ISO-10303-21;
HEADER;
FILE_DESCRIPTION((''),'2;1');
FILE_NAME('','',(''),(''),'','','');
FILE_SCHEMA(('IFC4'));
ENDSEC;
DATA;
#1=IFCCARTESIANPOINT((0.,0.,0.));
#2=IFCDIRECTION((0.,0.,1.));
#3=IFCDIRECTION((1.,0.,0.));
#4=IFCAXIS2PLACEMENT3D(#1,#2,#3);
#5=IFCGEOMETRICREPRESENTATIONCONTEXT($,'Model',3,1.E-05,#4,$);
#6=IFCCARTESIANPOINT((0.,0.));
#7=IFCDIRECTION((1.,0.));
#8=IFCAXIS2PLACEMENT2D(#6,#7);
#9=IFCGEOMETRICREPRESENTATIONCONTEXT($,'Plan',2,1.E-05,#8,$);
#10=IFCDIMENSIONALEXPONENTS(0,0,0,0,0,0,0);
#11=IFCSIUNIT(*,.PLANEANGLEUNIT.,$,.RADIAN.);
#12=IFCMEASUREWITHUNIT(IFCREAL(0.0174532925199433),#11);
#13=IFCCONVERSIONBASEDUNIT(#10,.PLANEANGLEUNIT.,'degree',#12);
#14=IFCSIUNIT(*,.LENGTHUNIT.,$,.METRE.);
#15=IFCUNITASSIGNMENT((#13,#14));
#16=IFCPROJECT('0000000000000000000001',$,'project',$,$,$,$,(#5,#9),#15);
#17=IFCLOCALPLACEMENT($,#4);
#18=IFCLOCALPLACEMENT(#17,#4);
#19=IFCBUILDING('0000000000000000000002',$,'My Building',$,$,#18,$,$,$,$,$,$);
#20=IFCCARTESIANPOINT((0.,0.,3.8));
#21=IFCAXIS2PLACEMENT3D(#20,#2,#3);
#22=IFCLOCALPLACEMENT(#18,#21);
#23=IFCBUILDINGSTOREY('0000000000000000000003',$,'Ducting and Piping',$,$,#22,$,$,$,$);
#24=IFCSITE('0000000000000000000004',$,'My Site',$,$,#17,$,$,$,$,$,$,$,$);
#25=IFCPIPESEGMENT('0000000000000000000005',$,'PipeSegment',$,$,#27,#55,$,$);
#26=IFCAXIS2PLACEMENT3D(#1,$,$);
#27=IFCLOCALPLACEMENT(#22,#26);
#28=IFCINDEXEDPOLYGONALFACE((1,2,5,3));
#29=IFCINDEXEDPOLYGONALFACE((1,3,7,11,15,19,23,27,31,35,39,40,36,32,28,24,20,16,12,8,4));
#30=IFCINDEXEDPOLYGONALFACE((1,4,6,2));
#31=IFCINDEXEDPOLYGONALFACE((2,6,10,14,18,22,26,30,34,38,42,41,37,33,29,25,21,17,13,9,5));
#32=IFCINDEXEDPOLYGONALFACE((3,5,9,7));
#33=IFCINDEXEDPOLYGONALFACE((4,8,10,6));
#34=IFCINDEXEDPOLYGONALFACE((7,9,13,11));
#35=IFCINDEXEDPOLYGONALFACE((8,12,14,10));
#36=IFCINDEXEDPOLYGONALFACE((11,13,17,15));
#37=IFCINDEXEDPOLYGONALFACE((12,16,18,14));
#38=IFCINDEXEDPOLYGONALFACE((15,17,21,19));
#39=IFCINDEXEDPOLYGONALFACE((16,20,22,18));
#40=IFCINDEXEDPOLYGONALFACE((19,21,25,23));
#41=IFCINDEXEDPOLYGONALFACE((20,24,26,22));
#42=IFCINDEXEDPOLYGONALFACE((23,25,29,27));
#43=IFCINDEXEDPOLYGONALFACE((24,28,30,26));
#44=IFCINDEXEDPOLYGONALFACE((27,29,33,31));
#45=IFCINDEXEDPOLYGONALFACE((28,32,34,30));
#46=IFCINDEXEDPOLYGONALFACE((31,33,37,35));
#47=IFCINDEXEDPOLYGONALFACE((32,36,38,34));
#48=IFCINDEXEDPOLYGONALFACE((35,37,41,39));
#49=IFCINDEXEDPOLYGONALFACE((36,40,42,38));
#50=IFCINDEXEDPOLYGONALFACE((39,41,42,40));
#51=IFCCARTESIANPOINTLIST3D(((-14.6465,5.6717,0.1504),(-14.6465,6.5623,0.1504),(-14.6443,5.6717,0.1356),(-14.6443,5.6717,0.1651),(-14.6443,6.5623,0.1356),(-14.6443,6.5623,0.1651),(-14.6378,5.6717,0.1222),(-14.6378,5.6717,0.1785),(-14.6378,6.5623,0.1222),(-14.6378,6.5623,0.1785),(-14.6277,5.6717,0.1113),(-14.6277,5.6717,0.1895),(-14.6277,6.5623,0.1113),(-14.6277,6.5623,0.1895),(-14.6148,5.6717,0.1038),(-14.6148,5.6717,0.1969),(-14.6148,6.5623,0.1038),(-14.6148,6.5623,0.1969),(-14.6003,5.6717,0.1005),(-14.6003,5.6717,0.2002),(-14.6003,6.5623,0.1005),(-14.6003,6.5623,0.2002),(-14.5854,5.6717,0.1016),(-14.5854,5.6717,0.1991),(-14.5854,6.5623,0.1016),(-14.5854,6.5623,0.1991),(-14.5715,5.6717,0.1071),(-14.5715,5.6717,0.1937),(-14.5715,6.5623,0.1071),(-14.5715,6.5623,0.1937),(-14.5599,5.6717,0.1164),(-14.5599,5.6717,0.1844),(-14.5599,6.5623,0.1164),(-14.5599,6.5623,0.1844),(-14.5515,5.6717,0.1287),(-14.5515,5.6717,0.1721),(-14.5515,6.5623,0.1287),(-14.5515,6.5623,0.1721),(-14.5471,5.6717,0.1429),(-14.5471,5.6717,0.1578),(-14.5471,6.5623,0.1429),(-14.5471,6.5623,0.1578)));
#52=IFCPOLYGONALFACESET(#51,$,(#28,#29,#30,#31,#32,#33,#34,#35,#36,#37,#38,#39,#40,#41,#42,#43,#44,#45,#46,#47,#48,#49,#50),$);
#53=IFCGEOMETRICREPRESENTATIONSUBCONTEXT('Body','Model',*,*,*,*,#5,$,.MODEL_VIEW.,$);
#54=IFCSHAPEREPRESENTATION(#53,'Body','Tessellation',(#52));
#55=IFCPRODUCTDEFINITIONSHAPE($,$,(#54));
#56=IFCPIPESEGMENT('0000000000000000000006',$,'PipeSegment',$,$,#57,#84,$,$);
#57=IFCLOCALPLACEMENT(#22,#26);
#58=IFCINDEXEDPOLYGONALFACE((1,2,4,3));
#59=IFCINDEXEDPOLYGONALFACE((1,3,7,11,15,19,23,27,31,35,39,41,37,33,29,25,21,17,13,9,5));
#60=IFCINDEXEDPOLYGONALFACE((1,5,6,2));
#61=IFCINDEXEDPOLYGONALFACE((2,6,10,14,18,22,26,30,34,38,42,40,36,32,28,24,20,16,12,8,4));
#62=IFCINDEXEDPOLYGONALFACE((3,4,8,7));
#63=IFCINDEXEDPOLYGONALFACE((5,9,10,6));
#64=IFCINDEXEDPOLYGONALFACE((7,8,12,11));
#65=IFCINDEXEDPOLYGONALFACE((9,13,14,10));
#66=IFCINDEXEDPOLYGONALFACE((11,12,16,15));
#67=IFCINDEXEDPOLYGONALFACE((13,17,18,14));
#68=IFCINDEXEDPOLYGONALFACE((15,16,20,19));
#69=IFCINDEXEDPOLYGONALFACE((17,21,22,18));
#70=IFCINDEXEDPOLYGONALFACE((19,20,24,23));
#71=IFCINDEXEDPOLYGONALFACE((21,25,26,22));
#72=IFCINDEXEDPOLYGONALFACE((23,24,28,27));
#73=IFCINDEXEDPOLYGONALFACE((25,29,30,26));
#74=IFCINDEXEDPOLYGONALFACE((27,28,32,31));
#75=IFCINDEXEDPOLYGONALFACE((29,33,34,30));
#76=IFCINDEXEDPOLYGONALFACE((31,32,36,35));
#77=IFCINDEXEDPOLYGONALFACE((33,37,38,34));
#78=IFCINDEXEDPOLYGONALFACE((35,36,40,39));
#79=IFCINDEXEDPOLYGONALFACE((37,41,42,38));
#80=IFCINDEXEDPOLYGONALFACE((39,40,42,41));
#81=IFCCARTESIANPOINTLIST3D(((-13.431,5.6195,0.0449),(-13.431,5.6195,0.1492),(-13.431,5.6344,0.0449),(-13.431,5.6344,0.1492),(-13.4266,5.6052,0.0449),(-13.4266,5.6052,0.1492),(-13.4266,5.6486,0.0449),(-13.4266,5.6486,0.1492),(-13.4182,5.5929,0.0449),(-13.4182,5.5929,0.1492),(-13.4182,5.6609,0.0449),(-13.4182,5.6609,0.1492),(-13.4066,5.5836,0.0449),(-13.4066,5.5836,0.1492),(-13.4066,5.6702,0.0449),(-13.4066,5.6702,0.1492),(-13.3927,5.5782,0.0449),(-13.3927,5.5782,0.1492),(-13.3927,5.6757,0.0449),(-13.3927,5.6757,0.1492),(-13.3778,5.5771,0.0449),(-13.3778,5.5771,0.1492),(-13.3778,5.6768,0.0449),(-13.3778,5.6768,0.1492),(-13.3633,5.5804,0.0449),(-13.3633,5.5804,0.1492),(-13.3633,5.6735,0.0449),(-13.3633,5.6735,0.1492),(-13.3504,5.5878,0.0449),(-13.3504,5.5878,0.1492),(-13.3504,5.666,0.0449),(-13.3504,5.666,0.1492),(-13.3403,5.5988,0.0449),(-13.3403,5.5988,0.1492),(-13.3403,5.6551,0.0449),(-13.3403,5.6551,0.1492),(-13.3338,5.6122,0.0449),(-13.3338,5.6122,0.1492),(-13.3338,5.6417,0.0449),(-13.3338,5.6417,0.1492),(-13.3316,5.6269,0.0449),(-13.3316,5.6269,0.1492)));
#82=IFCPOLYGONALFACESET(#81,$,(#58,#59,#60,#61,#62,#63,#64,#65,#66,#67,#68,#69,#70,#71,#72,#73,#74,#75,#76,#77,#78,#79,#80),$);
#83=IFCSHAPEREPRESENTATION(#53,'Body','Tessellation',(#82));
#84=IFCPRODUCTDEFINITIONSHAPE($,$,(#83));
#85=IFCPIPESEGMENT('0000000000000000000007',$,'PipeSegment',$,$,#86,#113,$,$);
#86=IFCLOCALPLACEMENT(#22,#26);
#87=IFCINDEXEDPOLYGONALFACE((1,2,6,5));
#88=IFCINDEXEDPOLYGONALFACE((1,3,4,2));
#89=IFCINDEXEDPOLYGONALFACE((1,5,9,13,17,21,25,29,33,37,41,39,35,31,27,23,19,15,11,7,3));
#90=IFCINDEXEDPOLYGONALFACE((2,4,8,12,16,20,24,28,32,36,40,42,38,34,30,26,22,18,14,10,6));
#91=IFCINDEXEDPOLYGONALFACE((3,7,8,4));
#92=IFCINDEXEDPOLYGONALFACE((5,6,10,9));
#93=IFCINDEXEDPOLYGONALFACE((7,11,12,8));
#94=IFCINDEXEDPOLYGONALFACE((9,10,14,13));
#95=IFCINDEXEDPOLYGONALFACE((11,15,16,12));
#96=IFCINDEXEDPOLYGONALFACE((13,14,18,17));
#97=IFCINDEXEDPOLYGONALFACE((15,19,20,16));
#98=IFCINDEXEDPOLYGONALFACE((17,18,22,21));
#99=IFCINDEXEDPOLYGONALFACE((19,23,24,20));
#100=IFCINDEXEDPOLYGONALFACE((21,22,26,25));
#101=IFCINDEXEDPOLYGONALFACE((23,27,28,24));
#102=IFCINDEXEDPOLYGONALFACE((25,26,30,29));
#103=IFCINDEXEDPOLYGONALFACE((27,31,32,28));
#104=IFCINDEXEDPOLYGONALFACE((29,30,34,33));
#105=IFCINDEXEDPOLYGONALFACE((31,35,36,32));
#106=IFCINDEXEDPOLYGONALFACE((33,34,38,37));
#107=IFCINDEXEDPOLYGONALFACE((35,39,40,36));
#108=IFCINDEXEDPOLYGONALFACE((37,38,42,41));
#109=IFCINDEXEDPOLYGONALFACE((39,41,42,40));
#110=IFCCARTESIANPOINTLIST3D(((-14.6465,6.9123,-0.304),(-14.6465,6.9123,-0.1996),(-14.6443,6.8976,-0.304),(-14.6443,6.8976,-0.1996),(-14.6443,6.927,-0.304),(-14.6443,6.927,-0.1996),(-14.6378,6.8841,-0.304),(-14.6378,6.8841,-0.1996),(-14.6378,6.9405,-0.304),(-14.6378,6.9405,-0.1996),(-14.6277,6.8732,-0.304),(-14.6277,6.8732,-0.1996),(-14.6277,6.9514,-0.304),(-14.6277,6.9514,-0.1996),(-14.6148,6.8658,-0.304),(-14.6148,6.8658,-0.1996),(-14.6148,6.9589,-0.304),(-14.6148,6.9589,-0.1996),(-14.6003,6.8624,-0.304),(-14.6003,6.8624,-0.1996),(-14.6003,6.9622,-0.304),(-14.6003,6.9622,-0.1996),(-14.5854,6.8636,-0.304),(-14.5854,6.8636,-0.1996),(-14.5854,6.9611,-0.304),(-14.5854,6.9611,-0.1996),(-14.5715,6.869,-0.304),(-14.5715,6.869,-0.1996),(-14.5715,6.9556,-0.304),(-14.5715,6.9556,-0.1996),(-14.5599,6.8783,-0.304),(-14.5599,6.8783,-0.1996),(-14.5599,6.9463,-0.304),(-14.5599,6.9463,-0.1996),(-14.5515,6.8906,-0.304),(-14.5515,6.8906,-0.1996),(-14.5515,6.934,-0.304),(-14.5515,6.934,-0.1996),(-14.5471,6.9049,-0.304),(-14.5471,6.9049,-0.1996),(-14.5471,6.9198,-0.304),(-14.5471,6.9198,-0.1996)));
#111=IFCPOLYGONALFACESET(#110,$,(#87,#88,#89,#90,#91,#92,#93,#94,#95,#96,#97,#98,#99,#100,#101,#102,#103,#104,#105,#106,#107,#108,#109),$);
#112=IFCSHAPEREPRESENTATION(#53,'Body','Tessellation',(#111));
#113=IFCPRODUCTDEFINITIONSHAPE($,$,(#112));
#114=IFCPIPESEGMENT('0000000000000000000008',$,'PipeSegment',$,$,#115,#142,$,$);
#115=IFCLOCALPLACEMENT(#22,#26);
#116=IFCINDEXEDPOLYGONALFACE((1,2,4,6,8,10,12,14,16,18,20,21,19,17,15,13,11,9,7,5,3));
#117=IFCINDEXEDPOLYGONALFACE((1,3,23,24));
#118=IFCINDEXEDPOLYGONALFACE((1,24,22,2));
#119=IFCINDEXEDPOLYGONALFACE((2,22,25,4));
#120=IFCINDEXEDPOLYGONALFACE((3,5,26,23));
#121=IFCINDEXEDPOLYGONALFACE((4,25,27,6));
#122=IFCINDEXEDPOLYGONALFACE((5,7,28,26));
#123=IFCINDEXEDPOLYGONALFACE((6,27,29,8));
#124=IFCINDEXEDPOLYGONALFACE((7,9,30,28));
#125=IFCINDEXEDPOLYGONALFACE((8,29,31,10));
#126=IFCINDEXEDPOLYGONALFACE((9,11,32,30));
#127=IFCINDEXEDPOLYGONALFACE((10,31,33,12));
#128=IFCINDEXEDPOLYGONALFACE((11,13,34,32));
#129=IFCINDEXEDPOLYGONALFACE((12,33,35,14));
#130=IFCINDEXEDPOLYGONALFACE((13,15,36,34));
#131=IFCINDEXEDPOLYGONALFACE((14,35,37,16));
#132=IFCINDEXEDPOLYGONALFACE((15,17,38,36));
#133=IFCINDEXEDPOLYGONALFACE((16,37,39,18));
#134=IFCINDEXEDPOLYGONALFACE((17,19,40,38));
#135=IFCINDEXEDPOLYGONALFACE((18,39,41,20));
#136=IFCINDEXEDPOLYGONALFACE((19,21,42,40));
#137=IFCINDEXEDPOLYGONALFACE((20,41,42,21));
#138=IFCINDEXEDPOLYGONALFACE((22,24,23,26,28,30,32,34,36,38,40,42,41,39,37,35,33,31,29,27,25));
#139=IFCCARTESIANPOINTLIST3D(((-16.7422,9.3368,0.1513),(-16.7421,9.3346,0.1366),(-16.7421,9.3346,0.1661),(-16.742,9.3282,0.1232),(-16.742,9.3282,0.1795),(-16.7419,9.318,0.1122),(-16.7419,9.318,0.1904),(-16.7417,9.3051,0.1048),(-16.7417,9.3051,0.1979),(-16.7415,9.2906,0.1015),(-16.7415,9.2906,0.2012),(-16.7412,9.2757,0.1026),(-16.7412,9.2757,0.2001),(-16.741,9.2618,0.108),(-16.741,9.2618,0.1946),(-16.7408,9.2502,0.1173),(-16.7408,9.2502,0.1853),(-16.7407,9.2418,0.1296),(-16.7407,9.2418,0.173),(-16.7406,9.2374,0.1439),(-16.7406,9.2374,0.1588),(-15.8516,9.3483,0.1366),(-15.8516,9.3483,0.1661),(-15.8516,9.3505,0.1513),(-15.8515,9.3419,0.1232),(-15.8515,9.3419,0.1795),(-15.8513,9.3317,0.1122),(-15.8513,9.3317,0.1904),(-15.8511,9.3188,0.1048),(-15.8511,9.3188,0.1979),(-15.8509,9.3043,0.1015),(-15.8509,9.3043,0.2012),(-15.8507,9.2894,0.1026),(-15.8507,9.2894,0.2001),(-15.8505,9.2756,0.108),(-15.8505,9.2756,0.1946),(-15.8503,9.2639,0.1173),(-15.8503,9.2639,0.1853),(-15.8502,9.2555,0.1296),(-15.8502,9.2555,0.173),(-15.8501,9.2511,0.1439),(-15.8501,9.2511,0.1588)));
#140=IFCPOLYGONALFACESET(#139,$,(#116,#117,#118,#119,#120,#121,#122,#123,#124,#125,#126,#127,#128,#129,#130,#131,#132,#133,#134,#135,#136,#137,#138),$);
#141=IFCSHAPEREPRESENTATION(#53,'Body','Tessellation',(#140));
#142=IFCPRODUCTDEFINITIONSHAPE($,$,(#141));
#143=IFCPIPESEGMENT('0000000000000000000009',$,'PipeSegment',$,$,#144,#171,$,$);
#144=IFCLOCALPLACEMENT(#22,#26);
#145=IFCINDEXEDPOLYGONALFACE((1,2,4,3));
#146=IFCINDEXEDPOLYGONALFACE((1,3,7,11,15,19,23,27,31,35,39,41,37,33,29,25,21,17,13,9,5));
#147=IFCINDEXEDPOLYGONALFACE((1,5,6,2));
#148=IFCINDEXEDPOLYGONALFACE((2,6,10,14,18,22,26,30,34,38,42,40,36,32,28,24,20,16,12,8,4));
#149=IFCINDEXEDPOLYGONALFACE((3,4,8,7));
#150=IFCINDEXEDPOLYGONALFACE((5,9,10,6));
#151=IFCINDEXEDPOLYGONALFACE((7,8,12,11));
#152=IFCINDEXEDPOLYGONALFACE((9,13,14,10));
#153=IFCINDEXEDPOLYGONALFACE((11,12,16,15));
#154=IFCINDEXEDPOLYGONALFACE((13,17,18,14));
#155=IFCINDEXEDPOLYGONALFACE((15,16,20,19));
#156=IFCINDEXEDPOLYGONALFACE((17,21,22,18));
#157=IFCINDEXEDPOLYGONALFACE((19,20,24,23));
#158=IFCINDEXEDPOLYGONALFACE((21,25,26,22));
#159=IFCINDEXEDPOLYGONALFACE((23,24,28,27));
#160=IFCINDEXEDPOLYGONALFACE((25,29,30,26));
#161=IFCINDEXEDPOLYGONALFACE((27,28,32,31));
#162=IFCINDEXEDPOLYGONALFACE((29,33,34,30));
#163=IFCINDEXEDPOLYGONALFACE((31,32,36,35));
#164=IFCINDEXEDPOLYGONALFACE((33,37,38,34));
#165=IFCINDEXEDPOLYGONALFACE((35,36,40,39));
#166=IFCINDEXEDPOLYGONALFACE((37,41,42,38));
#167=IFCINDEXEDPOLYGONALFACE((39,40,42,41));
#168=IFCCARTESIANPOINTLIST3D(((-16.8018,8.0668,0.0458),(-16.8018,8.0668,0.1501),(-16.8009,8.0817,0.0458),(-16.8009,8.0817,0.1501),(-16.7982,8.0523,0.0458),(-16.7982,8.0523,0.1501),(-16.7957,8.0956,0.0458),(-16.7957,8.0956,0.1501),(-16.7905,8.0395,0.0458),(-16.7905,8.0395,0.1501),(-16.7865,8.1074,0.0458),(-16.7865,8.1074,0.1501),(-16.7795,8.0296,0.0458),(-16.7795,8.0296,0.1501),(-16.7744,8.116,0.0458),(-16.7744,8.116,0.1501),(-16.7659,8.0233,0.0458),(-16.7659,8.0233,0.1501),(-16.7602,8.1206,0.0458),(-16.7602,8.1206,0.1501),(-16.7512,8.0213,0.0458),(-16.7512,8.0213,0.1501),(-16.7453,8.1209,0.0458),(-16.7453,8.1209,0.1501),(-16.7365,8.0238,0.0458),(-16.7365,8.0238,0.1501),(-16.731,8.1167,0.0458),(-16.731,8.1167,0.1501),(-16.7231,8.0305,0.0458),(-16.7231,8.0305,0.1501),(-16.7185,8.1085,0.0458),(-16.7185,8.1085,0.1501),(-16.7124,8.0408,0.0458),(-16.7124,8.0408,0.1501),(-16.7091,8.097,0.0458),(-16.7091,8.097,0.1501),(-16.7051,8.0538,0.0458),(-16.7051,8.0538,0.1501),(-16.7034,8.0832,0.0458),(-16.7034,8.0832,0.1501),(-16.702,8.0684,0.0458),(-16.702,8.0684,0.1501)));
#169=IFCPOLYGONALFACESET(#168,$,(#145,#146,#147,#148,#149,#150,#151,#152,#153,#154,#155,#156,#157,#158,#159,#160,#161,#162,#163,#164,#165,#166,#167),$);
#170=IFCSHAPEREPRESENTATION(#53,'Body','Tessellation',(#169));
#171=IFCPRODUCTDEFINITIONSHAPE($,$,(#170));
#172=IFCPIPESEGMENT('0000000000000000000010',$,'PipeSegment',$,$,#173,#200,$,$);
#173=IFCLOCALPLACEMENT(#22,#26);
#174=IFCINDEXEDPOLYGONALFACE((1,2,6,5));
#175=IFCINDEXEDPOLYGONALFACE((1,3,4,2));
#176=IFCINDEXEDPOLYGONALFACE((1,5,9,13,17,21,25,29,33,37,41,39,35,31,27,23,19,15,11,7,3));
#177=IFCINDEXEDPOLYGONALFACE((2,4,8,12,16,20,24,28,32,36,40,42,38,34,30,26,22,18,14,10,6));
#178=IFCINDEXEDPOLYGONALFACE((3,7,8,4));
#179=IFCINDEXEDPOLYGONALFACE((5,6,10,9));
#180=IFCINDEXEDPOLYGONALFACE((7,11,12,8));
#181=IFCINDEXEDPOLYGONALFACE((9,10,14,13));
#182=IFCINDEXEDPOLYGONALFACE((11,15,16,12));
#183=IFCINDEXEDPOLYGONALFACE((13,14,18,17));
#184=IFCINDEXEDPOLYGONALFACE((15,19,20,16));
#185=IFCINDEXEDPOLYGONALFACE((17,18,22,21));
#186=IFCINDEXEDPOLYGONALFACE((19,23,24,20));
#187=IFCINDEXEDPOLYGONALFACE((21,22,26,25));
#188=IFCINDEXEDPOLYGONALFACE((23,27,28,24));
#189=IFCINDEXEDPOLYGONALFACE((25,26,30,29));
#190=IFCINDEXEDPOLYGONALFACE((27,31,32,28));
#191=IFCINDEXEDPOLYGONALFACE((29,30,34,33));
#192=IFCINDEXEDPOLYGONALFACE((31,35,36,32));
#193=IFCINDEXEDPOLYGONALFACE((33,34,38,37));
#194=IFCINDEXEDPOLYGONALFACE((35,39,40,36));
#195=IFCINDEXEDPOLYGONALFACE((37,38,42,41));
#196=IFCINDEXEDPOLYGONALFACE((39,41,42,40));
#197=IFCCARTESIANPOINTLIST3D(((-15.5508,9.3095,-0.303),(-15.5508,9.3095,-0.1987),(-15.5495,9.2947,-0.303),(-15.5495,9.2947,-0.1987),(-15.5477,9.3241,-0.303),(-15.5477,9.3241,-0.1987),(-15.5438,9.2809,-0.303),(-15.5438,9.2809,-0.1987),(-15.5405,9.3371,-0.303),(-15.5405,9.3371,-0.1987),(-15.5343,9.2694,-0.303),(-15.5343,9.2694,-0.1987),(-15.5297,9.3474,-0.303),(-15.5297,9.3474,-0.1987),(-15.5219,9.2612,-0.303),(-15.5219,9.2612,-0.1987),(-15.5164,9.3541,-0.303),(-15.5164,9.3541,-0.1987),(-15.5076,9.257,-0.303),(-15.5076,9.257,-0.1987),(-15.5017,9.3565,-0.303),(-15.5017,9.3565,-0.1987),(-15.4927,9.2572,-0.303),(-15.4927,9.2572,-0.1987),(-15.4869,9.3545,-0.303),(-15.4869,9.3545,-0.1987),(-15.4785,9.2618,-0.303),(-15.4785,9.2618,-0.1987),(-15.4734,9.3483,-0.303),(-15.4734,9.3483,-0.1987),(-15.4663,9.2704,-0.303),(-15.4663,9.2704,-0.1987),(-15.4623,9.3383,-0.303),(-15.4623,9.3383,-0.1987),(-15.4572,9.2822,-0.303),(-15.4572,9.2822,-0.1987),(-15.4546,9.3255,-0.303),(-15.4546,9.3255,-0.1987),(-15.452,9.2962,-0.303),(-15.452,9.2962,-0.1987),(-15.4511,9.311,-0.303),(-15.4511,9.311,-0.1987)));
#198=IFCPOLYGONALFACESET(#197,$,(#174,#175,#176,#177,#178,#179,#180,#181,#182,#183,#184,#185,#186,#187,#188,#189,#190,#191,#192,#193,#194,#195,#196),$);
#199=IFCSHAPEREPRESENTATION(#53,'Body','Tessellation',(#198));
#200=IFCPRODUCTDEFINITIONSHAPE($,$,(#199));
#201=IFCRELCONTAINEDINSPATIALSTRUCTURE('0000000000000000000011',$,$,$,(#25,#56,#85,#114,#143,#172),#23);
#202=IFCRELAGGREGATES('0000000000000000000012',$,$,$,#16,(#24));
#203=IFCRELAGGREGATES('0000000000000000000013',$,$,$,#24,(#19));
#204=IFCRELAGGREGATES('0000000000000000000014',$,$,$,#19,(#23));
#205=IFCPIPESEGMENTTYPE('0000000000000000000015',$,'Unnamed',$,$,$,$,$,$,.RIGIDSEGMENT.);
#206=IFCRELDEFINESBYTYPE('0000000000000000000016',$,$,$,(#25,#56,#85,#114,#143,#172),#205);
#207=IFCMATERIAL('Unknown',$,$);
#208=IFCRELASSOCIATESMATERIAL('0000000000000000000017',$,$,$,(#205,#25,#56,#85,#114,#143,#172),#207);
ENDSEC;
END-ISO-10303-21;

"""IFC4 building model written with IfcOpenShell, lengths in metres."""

from ifc_helpers import new_model, entity, si_unit, converted_unit, frame, origin_with_axes, origin_2d_with_axis, place, context, subcontext, project, spatial, circle, extrude, material, material_profile, profile_set, profile_usage, type_object, element, save


model = new_model("IFC4")

# Units and contexts
model_context = context("Model", 3, precision=1e-05, world=origin_with_axes())
plan_context = context("Plan", 2, precision=1e-05, world=origin_2d_with_axis())
body_context = subcontext(model_context, "Body", "Model", "MODEL_VIEW")
ifc_project = project(units=[converted_unit("PLANEANGLEUNIT", "degree", entity("IfcReal", 0.0174532925199433), si_unit("PLANEANGLEUNIT", "RADIAN"), dimensions=[0, 0, 0, 0, 0, 0, 0]), si_unit("LENGTHUNIT", "METRE")], contexts=[model_context, plan_context])

# Site, building, storey
site_placement = place(None, origin_with_axes())
site = spatial("IfcSite", under=ifc_project, at=site_placement, Name="My Site")
building_placement = place(site_placement, origin_with_axes())
building = spatial("IfcBuilding", under=site, at=building_placement, Name="My Building")
storey_placement = place(building_placement, frame((0.0, 0.0, 3.8), z_axis=(0.0, 0.0, 1.0), x_axis=(1.0, 0.0, 0.0)))
storey = spatial("IfcBuildingStorey", under=building, at=storey_placement, Name="Ducting and Piping")

# Pipe segments
ifc_material = material(Name="Unknown")
ifc_material_profile_1 = material_profile(ifc_material, circle(Radius=0.05))
ifc_profile_set_1 = profile_set([ifc_material_profile_1])
ifc_profile_usage_1 = profile_usage(ifc_profile_set_1, cardinal=5)
pipe_segment_type = type_object("IfcPipeSegmentType", Name="Unnamed", PredefinedType="RIGIDSEGMENT", material=ifc_profile_set_1)
pipe_segment_1_placement = place(storey_placement, frame((-14.5965, 5.6717, 0.1504), z_axis=(0.0, 1.0, 0.0), x_axis=(-1.0, 0.0, 0.0)))
element("IfcPipeSegment", 1, at=pipe_segment_1_placement, inside=storey, type_object=pipe_segment_type, material=ifc_profile_usage_1, Name="PipeSegment", context=body_context, shape_type="SweptSolid", body=[
    extrude(circle(Radius=0.05), origin_with_axes(), (0.0, 0.0, 1.0), 0.8907),
])
ifc_profile_usage_2 = profile_usage(ifc_profile_set_1, cardinal=5)
pipe_segment_2_placement = place(storey_placement, frame((-13.3816, 5.6269, 0.0449), z_axis=(0.0, 0.0, 1.0), x_axis=(1.0, 0.00006, 0.0)))
element("IfcPipeSegment", 2, at=pipe_segment_2_placement, inside=storey, type_object=pipe_segment_type, material=ifc_profile_usage_2, Name="PipeSegment", context=body_context, shape_type="SweptSolid", body=[
    extrude(circle(Radius=0.05), origin_with_axes(), (0.0, 0.0, 1.0), 0.1043),
])
ifc_profile_usage_3 = profile_usage(ifc_profile_set_1, cardinal=5)
pipe_segment_3_placement = place(storey_placement, frame((-14.5965, 6.9123, -0.304), z_axis=(0.0, 0.0, 1.0), x_axis=(-1.0, 0.0, 0.0)))
element("IfcPipeSegment", 3, at=pipe_segment_3_placement, inside=storey, type_object=pipe_segment_type, material=ifc_profile_usage_3, Name="PipeSegment", context=body_context, shape_type="SweptSolid", body=[
    extrude(circle(Radius=0.05), origin_with_axes(), (0.0, 0.0, 1.0), 0.1043),
])
ifc_profile_usage_4 = profile_usage(ifc_profile_set_1, cardinal=5)
pipe_segment_4_placement = place(storey_placement, frame((-16.7414, 9.2868, 0.1513), z_axis=(0.999882, 0.015389, 0.0), x_axis=(-0.015389, 0.999882, 0.0)))
element("IfcPipeSegment", 4, at=pipe_segment_4_placement, inside=storey, type_object=pipe_segment_type, material=ifc_profile_usage_4, Name="PipeSegment", context=body_context, shape_type="SweptSolid", body=[
    extrude(circle(Radius=0.05), origin_with_axes(), (0.0, 0.0, 1.0), 0.8907),
])
ifc_profile_usage_5 = profile_usage(ifc_profile_set_1, cardinal=5)
pipe_segment_5_placement = place(storey_placement, frame((-16.752, 8.0713, 0.0458), z_axis=(0.0, 0.0, 1.0), x_axis=(0.015928, -0.999873, 0.0)))
element("IfcPipeSegment", 5, at=pipe_segment_5_placement, inside=storey, type_object=pipe_segment_type, material=ifc_profile_usage_5, Name="PipeSegment", context=body_context, shape_type="SweptSolid", body=[
    extrude(circle(Radius=0.05), origin_with_axes(), (0.0, 0.0, 1.0), 0.1043),
])
ifc_profile_usage_6 = profile_usage(ifc_profile_set_1, cardinal=5)
pipe_segment_6_placement = place(storey_placement, frame((-15.5009, 9.3065, -0.303), z_axis=(0.0, 0.0, 1.0), x_axis=(-0.015371, 0.999882, 0.0)))
element("IfcPipeSegment", 6, at=pipe_segment_6_placement, inside=storey, type_object=pipe_segment_type, material=ifc_profile_usage_6, Name="PipeSegment", context=body_context, shape_type="SweptSolid", body=[
    extrude(circle(Radius=0.05), origin_with_axes(), (0.0, 0.0, 1.0), 0.1043),
])

save(model, "model.ifc")
